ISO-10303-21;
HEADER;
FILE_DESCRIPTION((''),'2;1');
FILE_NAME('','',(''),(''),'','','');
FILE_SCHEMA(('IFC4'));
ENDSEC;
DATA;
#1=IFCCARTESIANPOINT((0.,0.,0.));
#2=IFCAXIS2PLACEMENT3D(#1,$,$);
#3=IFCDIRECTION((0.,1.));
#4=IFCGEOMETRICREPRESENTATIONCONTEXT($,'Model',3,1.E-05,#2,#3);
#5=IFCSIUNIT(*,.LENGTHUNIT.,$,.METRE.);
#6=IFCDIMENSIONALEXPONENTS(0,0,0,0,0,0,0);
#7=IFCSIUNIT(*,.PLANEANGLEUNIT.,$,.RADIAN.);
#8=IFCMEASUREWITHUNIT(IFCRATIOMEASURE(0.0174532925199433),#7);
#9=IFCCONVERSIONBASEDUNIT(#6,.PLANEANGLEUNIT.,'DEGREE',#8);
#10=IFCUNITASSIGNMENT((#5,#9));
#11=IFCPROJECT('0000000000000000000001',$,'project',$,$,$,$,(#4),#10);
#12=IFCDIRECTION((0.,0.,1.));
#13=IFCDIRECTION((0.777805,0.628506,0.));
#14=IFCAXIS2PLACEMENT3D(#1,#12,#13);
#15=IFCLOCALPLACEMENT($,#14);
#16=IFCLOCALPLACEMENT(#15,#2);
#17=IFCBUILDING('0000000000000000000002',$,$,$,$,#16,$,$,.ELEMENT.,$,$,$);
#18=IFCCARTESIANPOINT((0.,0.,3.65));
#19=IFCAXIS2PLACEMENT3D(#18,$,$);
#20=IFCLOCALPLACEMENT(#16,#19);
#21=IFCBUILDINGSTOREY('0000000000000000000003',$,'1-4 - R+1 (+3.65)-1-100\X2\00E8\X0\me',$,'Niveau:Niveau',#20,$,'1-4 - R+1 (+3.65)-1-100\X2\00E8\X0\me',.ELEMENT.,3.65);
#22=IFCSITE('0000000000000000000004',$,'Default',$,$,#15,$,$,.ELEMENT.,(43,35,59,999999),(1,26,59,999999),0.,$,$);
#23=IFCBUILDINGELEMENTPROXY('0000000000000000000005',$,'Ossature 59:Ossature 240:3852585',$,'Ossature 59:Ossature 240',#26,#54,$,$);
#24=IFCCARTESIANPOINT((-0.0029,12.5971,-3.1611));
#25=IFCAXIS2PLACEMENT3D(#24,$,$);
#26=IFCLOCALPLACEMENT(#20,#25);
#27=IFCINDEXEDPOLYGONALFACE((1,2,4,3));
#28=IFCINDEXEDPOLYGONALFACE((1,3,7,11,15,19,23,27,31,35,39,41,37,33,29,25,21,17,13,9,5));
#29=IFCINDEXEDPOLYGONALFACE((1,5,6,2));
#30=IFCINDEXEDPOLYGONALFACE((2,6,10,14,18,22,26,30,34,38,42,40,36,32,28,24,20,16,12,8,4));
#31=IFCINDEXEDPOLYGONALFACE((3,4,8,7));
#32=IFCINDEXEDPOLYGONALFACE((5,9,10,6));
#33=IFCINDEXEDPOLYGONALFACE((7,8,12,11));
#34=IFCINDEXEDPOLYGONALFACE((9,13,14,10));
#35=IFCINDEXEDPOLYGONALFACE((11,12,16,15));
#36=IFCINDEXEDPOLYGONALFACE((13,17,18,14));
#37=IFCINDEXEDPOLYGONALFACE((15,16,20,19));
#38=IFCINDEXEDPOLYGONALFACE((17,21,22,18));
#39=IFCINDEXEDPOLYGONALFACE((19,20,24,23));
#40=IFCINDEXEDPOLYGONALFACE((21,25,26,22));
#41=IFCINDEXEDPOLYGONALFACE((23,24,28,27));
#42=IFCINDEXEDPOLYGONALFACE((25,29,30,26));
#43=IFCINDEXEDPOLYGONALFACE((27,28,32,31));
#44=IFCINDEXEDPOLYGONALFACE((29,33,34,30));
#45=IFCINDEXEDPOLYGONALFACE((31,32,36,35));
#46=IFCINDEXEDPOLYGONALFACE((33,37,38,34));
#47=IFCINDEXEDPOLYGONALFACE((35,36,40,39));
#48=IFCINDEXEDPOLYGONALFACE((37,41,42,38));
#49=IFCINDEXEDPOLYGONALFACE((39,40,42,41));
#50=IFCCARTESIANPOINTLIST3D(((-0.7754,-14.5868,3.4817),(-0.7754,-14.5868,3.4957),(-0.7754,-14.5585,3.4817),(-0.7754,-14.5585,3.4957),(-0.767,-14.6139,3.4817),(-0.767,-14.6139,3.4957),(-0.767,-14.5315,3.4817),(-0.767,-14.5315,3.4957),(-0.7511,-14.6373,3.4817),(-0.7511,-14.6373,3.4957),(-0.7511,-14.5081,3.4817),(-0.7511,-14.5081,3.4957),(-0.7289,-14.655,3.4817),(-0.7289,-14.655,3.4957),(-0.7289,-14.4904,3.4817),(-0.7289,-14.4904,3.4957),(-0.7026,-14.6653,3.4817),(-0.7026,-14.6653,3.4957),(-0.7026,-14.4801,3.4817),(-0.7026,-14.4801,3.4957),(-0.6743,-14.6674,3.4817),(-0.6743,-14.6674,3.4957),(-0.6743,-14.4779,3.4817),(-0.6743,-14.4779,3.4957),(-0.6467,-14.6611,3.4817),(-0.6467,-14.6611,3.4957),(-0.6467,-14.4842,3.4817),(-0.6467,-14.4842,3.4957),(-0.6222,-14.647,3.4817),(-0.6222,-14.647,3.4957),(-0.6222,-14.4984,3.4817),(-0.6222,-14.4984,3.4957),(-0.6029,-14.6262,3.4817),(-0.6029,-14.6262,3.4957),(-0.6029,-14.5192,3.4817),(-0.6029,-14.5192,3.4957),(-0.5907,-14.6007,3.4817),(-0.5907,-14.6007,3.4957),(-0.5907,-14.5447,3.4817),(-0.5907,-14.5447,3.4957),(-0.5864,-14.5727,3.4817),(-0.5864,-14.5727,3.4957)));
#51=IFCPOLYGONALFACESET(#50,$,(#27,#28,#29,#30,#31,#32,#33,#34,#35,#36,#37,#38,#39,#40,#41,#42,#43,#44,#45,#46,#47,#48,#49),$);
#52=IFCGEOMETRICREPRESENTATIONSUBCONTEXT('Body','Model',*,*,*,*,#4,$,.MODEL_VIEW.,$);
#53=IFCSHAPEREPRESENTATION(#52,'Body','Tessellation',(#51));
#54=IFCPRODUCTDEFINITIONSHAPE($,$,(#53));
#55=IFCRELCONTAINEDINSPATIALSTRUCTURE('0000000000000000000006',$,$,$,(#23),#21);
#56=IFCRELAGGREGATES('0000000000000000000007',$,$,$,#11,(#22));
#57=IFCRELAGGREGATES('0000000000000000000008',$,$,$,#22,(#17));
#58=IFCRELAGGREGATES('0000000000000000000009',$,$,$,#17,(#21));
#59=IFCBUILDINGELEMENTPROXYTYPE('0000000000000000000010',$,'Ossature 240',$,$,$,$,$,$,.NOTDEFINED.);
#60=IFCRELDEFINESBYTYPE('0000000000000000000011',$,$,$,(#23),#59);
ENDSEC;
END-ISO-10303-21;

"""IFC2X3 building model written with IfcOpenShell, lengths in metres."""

from ifc_helpers import new_model, entity, si_unit, converted_unit, direction, frame, origin, origin_2d_with_axis, place, context, subcontext, project, spatial, circle, extrude, source, transform, mapped, type_object, type_shapes, element, save


model = new_model("IFC2X3")

# Units and contexts
model_context = context("Model", 3, precision=1e-05, world=origin(), true_north=direction((0.0, 1.0)))
body_context = subcontext(model_context, "Body", "Model", "MODEL_VIEW")
ifc_project = project(units=[si_unit("LENGTHUNIT", "METRE"), converted_unit("PLANEANGLEUNIT", "DEGREE", entity("IfcRatioMeasure", 0.0174532925199433), si_unit("PLANEANGLEUNIT", "RADIAN"), dimensions=[0, 0, 0, 0, 0, 0, 0])], contexts=[model_context])

# Site, building, storey
site_placement = place(None, frame((0.0, 0.0, 0.0), z_axis=(0.0, 0.0, 1.0), x_axis=(0.777805, 0.628506, 0.0)))
site = spatial("IfcSite", under=ifc_project, at=site_placement, Name="Default", CompositionType="ELEMENT", RefLatitude=(43, 35, 59, 999999), RefLongitude=(1, 26, 59, 999999), RefElevation=0.0)
building_placement = place(site_placement, origin())
building = spatial("IfcBuilding", under=site, at=building_placement, CompositionType="ELEMENT")
storey_placement = place(building_placement, frame((0.0, 0.0, 3.65)))
storey = spatial("IfcBuildingStorey", under=building, at=storey_placement, Name="1-4 - R+1 (+3.65)-1-100ème", ObjectType="Niveau:Niveau", LongName="1-4 - R+1 (+3.65)-1-100ème", CompositionType="ELEMENT", Elevation=3.65)

# Building element proxy
building_element_proxy_type_1 = type_object("IfcBuildingElementProxyType", Name="Ossature 240", PredefinedType="NOTDEFINED")
shared_shape_1 = source(origin(), body_context, "Body", "SweptSolid", [
    extrude(circle(Radius=0.095, at=origin_2d_with_axis()), frame((-0.6814, -14.5727, 3.4817)), (0.0, 0.0, 1.0), 0.014),
])
type_shapes(building_element_proxy_type_1, [shared_shape_1])
proxy_1_placement = place(storey_placement, frame((-0.0029, 12.5971, -3.1611)))
element("IfcBuildingElementProxy", 1, at=proxy_1_placement, inside=storey, type_object=building_element_proxy_type_1, Name="Ossature 59:Ossature 240:3852585", ObjectType="Ossature 59:Ossature 240", context=body_context, shape_type="MappedRepresentation", body=[
    mapped(shared_shape_1, transform((0.0, 0.0, 0.0), scale=1.0)),
])

save(model, "model.ifc")
